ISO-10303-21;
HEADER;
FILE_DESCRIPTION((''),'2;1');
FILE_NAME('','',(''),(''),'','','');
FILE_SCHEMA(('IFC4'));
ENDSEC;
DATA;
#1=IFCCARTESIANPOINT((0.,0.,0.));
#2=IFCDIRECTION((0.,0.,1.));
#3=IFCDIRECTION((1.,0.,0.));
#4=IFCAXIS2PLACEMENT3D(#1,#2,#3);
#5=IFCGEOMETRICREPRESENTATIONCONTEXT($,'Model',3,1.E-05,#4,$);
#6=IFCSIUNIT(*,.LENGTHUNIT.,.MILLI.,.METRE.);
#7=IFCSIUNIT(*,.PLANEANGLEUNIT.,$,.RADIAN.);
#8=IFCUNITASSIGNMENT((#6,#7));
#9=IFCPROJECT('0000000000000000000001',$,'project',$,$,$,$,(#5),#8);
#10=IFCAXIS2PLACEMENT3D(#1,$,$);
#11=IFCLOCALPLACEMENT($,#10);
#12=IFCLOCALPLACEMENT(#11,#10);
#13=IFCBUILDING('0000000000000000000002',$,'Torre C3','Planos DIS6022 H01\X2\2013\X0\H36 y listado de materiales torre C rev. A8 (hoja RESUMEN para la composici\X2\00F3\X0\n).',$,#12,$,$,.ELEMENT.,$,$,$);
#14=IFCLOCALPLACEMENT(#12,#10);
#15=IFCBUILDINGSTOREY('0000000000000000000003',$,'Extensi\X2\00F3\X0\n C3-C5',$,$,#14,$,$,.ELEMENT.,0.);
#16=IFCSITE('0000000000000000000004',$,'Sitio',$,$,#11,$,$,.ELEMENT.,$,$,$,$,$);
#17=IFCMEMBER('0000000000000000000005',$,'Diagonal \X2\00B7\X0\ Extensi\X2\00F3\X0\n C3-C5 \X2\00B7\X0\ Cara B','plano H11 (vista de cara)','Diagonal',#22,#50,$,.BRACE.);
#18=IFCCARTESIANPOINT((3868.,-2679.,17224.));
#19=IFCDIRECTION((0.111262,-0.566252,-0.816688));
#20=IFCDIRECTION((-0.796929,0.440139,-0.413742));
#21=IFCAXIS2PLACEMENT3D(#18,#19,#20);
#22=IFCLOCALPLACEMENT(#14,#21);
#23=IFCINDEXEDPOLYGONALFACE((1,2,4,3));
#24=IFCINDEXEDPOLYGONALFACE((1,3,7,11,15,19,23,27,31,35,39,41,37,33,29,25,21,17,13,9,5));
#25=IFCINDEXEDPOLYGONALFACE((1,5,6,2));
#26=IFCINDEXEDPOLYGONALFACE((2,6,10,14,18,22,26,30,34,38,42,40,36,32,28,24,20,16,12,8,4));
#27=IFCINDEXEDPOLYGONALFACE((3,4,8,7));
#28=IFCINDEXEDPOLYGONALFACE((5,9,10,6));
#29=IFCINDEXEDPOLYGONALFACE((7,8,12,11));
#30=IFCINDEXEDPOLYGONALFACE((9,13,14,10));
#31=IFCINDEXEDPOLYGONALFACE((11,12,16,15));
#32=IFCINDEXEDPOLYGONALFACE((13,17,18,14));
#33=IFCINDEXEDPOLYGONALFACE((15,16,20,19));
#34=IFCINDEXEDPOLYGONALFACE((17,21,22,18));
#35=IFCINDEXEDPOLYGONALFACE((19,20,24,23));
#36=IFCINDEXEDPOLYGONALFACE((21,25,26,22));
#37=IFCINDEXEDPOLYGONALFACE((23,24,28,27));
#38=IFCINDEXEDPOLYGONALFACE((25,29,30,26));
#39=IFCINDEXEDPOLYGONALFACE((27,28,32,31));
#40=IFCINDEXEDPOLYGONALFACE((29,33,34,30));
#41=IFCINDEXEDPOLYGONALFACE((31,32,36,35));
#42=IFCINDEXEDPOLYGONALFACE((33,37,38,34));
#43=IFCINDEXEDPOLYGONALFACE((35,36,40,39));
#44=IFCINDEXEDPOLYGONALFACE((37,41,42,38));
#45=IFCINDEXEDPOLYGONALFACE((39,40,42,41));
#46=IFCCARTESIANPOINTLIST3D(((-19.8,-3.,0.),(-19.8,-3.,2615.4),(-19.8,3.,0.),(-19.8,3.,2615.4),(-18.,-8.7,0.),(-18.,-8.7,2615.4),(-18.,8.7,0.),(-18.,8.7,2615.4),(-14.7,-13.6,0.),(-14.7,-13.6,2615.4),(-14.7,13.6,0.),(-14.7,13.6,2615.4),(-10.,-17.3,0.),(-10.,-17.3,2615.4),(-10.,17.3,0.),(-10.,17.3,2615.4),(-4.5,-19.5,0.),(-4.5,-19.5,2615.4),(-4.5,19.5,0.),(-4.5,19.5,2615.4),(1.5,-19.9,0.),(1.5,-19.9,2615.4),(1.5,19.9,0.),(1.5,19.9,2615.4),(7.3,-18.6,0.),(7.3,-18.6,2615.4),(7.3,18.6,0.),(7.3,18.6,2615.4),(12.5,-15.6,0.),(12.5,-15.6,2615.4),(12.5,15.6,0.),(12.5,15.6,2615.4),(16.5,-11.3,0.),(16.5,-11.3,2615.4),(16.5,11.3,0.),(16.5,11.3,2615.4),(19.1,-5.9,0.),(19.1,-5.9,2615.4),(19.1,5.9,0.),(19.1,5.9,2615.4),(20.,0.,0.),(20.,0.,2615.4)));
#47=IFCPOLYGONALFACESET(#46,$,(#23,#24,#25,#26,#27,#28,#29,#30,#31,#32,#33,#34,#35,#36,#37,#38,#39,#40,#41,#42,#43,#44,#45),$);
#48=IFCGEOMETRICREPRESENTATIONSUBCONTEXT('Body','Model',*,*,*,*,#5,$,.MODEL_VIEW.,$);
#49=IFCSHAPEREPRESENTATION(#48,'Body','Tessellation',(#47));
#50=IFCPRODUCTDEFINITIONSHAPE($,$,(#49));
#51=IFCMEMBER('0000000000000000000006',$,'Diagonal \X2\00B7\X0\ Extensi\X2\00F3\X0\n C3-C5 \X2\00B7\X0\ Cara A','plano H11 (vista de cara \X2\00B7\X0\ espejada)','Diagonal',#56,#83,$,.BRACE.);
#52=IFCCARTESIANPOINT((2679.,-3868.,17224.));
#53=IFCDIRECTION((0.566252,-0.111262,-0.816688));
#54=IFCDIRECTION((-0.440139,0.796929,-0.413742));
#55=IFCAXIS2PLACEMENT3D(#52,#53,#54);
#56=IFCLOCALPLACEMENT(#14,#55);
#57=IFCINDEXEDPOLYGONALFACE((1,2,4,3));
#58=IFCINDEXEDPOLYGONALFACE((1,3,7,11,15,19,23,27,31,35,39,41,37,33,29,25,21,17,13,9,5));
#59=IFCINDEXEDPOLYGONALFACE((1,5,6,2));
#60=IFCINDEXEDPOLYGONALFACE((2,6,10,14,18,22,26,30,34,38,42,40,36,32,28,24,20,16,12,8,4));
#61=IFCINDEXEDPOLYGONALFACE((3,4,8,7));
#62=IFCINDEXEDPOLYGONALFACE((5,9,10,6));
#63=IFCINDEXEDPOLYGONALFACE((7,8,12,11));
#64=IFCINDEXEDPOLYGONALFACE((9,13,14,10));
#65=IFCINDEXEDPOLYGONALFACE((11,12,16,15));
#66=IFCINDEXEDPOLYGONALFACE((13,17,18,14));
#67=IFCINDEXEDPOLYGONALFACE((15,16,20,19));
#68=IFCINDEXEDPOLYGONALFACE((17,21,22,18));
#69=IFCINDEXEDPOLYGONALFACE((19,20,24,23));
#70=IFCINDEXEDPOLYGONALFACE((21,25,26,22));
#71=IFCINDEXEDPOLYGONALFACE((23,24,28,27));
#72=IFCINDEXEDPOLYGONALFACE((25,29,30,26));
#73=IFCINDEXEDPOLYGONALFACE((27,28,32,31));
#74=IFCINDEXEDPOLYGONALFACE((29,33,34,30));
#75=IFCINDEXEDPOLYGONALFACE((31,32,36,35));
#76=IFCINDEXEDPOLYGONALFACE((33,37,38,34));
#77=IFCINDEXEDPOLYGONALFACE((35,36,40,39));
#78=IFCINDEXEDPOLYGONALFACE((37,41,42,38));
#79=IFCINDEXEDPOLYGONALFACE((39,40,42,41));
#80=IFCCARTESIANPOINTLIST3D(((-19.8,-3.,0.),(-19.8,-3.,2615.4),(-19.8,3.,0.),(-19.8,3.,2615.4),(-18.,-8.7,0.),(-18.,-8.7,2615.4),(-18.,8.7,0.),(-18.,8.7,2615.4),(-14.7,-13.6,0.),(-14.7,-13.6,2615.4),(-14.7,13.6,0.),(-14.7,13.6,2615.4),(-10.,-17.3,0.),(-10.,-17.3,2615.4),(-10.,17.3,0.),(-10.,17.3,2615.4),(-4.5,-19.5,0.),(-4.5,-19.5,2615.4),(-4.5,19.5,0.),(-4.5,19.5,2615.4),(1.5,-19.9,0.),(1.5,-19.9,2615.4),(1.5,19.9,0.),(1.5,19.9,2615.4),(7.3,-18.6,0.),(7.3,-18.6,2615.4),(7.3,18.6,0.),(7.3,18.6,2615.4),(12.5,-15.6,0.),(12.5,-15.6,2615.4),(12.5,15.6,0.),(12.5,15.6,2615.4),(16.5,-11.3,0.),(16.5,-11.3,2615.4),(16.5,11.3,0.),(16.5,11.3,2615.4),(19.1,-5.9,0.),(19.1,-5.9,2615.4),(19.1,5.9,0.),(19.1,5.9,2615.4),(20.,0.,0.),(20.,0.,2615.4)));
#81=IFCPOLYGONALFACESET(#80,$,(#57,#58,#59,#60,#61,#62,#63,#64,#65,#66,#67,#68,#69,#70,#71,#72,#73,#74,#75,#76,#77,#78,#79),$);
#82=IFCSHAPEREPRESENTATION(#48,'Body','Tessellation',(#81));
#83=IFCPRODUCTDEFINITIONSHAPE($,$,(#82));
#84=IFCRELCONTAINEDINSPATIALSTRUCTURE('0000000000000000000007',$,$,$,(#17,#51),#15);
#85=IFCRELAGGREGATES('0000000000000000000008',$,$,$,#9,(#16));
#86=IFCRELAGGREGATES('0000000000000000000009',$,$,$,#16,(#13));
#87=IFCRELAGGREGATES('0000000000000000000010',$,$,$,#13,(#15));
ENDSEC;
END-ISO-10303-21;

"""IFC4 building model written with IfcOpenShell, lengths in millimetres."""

from ifc_helpers import new_model, si_unit, frame, origin, origin_with_axes, place, context, subcontext, project, spatial, circle, extrude, element, save


model = new_model("IFC4")

# Units and contexts
model_context = context("Model", 3, precision=1e-05, world=origin_with_axes())
body_context = subcontext(model_context, "Body", "Model", "MODEL_VIEW")
ifc_project = project(units=[si_unit("LENGTHUNIT", "METRE", prefix="MILLI"), si_unit("PLANEANGLEUNIT", "RADIAN")], contexts=[model_context])

# Site, building, storey
site_placement = place(None, origin())
site = spatial("IfcSite", under=ifc_project, at=site_placement, Name="Sitio", CompositionType="ELEMENT")
building_placement = place(site_placement, origin())
building = spatial("IfcBuilding", under=site, at=building_placement, Name="Torre C3", Description="Planos DIS6022 H01–H36 y listado de materiales torre C rev. A8 (hoja RESUMEN para la composición).", CompositionType="ELEMENT")
storey_placement = place(building_placement, origin())
storey = spatial("IfcBuildingStorey", under=building, at=storey_placement, Name="Extensión C3-C5", CompositionType="ELEMENT", Elevation=0.0)

# Members
for number, where, z_axis, x_axis, name, description in (
    (1, (3868.0, -2679.0, 17224.0), (0.111262, -0.566252, -0.816688), (-0.796929, 0.440139, -0.413742), "Diagonal · Extensión C3-C5 · Cara B", "plano H11 (vista de cara)"),
    (2, (2679.0, -3868.0, 17224.0), (0.566252, -0.111262, -0.816688), (-0.440139, 0.796929, -0.413742), "Diagonal · Extensión C3-C5 · Cara A", "plano H11 (vista de cara · espejada)"),
):
    element("IfcMember", number, at=place(storey_placement, frame(where, z_axis=z_axis, x_axis=x_axis)), inside=storey, Name=name, Description=description, ObjectType="Diagonal", PredefinedType="BRACE", context=body_context, shape_type="SweptSolid", body=[
        extrude(circle(Radius=20.0), None, (0.0, 0.0, 1.0), 2615.4),
    ])

save(model, "model.ifc")
